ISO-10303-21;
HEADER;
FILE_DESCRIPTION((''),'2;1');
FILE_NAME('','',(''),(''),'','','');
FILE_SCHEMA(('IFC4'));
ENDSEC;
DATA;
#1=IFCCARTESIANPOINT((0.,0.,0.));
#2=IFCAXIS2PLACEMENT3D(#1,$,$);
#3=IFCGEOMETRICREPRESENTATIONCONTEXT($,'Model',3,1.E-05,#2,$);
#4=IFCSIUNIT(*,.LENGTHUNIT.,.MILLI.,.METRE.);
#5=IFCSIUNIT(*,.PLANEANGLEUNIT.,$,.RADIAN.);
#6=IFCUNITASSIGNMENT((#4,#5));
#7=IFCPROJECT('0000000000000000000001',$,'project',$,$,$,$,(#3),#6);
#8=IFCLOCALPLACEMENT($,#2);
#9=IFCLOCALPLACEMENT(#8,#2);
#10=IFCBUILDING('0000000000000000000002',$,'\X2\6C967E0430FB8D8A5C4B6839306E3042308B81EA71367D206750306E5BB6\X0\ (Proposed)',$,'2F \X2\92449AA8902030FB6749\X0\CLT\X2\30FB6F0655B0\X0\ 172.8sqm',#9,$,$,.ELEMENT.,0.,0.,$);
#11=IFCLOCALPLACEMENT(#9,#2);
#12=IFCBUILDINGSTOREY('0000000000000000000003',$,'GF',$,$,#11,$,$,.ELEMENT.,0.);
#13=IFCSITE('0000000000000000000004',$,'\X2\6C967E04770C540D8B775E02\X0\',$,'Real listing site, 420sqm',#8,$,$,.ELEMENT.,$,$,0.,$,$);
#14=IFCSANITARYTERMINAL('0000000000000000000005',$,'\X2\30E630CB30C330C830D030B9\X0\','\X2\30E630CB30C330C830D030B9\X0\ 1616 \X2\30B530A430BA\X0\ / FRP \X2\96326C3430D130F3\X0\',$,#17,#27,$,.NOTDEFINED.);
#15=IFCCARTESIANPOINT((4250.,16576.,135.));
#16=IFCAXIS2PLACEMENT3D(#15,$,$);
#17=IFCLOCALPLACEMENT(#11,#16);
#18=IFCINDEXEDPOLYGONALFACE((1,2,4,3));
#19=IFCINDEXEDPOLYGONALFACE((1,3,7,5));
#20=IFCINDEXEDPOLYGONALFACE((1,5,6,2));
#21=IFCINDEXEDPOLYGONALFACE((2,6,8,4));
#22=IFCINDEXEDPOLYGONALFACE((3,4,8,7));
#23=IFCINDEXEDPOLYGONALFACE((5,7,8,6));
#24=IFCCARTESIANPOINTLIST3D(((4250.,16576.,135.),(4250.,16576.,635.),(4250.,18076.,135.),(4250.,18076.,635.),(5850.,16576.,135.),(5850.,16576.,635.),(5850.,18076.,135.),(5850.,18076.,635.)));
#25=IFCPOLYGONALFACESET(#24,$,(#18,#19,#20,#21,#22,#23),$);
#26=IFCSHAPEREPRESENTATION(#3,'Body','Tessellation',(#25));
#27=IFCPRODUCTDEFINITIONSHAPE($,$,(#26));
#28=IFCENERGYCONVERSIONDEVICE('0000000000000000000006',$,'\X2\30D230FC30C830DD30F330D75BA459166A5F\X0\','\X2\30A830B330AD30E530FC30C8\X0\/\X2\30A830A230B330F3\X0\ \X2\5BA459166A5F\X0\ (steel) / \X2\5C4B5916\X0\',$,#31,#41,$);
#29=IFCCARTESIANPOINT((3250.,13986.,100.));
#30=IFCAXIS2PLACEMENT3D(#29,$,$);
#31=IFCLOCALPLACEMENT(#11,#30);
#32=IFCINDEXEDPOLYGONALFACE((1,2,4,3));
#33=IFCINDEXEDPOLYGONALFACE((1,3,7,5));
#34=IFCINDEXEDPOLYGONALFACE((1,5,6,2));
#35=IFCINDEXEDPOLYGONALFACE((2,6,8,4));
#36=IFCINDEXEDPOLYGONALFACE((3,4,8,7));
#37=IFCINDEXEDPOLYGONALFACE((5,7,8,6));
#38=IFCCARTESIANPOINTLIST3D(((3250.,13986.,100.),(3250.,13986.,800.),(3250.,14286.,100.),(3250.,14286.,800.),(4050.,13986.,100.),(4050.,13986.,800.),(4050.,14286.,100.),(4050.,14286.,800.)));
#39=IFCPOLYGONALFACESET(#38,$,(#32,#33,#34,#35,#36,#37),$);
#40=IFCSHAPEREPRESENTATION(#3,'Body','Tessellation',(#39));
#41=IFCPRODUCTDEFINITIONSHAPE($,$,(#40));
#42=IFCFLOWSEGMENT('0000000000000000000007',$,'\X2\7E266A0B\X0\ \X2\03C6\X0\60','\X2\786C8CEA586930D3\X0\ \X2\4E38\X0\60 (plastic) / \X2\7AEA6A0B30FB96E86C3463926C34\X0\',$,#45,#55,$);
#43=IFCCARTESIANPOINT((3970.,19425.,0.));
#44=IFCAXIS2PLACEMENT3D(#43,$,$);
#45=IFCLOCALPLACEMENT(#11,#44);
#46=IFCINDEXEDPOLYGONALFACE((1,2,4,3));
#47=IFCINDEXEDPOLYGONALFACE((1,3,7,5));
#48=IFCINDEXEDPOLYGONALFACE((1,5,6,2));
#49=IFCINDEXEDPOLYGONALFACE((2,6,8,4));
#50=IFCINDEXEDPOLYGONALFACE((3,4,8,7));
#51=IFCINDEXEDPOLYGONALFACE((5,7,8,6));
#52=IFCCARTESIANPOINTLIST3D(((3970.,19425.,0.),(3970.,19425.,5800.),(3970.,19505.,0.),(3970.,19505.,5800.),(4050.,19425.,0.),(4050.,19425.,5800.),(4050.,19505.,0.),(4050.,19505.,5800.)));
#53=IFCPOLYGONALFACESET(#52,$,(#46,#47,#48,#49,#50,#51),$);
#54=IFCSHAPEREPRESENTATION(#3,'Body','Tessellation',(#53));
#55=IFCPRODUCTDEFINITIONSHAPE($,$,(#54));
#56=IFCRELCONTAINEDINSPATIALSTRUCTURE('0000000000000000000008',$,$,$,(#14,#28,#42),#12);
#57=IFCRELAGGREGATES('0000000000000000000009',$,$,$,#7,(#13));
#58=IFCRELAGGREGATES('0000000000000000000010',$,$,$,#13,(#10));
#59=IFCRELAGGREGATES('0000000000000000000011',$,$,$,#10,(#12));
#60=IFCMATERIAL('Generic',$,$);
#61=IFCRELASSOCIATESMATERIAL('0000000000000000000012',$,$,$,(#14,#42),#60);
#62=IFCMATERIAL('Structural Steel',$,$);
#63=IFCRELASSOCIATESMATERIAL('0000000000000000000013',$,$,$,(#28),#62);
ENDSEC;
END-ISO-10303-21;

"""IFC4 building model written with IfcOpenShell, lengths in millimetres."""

from ifc_helpers import new_model, si_unit, frame, frame_2d, origin, place, context, project, spatial, rectangle, extrude, material, element, save


model = new_model("IFC4")

# Units and contexts
model_context = context("Model", 3, precision=1e-05, world=origin())
ifc_project = project(units=[si_unit("LENGTHUNIT", "METRE", prefix="MILLI"), si_unit("PLANEANGLEUNIT", "RADIAN")], contexts=[model_context])

# Site, building, storey
site_placement = place(None, origin())
site = spatial("IfcSite", under=ifc_project, at=site_placement, Name="沖縄県名護市", ObjectType="Real listing site, 420sqm", CompositionType="ELEMENT", RefElevation=0.0)
building_placement = place(site_placement, origin())
building = spatial("IfcBuilding", under=site, at=building_placement, Name="沖縄・越屋根のある自然素材の家 (Proposed)", ObjectType="2F 鉄骨造・杉CLT・漆喰 172.8sqm", CompositionType="ELEMENT", ElevationOfRefHeight=0.0, ElevationOfTerrain=0.0)
storey_placement = place(building_placement, origin())
storey = spatial("IfcBuildingStorey", under=building, at=storey_placement, Name="GF", CompositionType="ELEMENT", Elevation=0.0)

# Shared definitions
ifc_material_1 = material(Name="Generic")

# Sanitary terminal
sanitary_terminal_placement = place(storey_placement, frame((4250.0, 16576.0, 135.0)))
element("IfcSanitaryTerminal", 1, at=sanitary_terminal_placement, inside=storey, material=ifc_material_1, Name="ユニットバス", Description="ユニットバス 1616 サイズ / FRP 防水パン", PredefinedType="NOTDEFINED", context=model_context, shape_type="SweptSolid", body=[
    extrude(rectangle(XDim=1600.0, YDim=1500.0, at=frame_2d((800.0, 750.0))), frame((4250.0, 16576.0, 135.0)), (0.0, 0.0, 1.0), 500.0),
])

# Energy conversion device
ifc_material_2 = material(Name="Structural Steel")
energy_conversion_device_placement = place(storey_placement, frame((3250.0, 13986.0, 100.0)))
element("IfcEnergyConversionDevice", 2, at=energy_conversion_device_placement, inside=storey, material=ifc_material_2, Name="ヒートポンプ室外機", Description="エコキュート/エアコン 室外機 (steel) / 屋外", context=model_context, shape_type="SweptSolid", body=[
    extrude(rectangle(XDim=800.0, YDim=300.0, at=frame_2d((400.0, 150.0))), frame((3250.0, 13986.0, 100.0)), (0.0, 0.0, 1.0), 700.0),
])

# Flow segment
flow_segment_placement = place(storey_placement, frame((3970.0, 19425.0, 0.0)))
element("IfcFlowSegment", 3, at=flow_segment_placement, inside=storey, material=ifc_material_1, Name="縦樋 φ60", Description="硬質塩ビ 丸60 (plastic) / 竪樋・雨水排水", context=model_context, shape_type="SweptSolid", body=[
    extrude(rectangle(XDim=80.0, YDim=80.0, at=frame_2d((40.0, 40.0))), frame((3970.0, 19425.0, 0.0)), (0.0, 0.0, 1.0), 5800.0),
])

save(model, "model.ifc")
